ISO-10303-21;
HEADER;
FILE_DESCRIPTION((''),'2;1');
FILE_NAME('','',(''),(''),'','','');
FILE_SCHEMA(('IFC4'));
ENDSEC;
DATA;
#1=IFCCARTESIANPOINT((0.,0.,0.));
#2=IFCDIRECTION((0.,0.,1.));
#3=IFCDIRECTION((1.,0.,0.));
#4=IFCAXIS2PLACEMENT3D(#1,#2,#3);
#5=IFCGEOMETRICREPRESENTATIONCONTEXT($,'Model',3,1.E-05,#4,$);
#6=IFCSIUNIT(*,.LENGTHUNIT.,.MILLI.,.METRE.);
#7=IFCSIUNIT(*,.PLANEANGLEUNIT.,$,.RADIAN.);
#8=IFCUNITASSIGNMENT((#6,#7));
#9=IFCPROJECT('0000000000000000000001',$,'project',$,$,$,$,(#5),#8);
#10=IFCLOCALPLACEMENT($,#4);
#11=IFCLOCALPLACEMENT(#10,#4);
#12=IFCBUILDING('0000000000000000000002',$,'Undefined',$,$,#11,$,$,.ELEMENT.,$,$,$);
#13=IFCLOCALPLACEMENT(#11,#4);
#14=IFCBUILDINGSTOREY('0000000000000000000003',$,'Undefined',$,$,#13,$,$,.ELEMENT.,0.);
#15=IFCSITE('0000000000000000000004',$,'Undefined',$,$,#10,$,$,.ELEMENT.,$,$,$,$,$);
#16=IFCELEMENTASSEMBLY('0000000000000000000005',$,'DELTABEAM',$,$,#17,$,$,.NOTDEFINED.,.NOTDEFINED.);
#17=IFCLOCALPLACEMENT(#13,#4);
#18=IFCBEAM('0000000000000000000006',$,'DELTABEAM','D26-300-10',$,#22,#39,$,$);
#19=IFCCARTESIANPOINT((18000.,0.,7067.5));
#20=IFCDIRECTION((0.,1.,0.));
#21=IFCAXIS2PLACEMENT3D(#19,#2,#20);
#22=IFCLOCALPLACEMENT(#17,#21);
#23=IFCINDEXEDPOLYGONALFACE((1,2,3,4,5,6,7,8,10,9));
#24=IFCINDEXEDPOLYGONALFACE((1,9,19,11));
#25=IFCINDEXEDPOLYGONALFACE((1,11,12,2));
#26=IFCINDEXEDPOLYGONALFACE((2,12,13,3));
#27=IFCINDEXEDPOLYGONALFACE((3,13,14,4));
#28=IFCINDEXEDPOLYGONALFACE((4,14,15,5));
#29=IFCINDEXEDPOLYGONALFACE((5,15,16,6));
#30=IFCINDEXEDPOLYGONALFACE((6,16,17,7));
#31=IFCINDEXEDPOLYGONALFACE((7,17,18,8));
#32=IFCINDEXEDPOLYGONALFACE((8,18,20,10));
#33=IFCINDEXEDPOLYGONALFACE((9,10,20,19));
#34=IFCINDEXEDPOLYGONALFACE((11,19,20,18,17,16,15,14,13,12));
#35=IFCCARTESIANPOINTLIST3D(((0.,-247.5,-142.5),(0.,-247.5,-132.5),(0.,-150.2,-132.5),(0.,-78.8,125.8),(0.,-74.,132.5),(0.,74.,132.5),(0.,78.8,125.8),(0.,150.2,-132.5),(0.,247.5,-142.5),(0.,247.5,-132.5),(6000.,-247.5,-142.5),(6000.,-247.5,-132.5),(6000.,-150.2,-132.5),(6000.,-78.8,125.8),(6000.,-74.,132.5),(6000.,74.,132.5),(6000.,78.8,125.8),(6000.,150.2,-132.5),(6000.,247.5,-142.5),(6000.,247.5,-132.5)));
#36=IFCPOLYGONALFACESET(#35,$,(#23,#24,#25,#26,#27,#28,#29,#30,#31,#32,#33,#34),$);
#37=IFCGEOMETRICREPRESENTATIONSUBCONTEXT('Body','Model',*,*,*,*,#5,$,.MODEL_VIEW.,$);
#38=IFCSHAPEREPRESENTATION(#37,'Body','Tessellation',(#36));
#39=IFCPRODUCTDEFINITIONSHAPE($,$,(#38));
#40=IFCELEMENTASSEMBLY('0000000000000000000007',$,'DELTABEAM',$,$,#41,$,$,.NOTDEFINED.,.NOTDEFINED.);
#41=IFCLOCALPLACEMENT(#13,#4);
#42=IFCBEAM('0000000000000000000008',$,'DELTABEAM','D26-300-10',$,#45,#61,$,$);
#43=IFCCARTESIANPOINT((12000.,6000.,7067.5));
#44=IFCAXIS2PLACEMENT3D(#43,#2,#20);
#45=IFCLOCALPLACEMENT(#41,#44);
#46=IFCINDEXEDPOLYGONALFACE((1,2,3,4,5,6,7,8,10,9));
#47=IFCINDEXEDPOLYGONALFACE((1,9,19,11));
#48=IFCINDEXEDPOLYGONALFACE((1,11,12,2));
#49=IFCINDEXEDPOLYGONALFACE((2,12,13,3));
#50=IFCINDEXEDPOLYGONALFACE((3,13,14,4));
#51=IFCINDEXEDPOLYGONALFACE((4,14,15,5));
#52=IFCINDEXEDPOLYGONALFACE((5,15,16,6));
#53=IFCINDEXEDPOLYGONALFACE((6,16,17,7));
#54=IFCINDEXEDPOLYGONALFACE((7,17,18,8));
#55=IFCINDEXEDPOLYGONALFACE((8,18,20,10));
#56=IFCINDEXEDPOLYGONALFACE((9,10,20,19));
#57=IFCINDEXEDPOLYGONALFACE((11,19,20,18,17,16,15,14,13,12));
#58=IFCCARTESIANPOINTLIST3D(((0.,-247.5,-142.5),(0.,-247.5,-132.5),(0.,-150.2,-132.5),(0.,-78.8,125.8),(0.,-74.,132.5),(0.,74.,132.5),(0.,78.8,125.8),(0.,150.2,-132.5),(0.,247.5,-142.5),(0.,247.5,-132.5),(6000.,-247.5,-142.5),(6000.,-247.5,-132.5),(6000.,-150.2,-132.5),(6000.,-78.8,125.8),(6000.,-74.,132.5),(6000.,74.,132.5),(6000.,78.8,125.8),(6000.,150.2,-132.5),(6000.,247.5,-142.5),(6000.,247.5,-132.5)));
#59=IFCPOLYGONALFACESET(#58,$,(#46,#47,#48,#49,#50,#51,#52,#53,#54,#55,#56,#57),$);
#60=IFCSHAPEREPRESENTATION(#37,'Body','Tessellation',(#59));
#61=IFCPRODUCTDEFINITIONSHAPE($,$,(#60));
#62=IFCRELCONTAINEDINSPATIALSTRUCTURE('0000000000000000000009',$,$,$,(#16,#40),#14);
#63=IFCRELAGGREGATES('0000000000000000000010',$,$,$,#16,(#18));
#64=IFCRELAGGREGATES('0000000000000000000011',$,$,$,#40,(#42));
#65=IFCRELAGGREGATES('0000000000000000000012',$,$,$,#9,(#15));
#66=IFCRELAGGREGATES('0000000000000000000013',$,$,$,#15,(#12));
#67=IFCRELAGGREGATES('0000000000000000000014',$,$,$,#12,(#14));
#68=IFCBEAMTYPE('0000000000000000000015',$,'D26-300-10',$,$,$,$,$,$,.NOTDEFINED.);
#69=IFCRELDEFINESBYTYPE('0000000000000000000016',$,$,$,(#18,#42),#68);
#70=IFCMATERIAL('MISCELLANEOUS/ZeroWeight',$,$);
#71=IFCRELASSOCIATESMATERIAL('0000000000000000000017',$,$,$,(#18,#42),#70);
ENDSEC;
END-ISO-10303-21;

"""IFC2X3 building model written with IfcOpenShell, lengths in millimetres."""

from ifc_helpers import new_model, si_unit, frame, origin_with_axes, place, context, subcontext, project, spatial, polyline, outline, extrude, material, type_object, element, aggregate, save


model = new_model("IFC2X3")

# Units and contexts
model_context = context("Model", 3, precision=1e-05, world=origin_with_axes())
body_context = subcontext(model_context, "Body", "Model", "MODEL_VIEW")
ifc_project = project(units=[si_unit("LENGTHUNIT", "METRE", prefix="MILLI"), si_unit("PLANEANGLEUNIT", "RADIAN")], contexts=[model_context])

# Site, building, storey
site_placement = place(None, origin_with_axes())
site = spatial("IfcSite", under=ifc_project, at=site_placement, Name="Undefined", CompositionType="ELEMENT")
building_placement = place(site_placement, origin_with_axes())
building = spatial("IfcBuilding", under=site, at=building_placement, Name="Undefined", CompositionType="ELEMENT")
storey_placement = place(building_placement, origin_with_axes())
storey = spatial("IfcBuildingStorey", under=building, at=storey_placement, Name="Undefined", CompositionType="ELEMENT", Elevation=0.0)

# Element assemblies, beams
assembly_1_placement = place(storey_placement, origin_with_axes())
assembly_1 = element("IfcElementAssembly", 1, at=assembly_1_placement, inside=storey, Name="DELTABEAM", AssemblyPlace="NOTDEFINED", PredefinedType="NOTDEFINED")
ifc_material_1 = material(Name="MISCELLANEOUS/ZeroWeight")
beam_type = type_object("IfcBeamType", Name="D26-300-10", PredefinedType="NOTDEFINED")
beam_1_placement = place(assembly_1_placement, frame((18000.0, 0.0, 7067.5), z_axis=(0.0, 0.0, 1.0), x_axis=(0.0, 1.0, 0.0)))
beam_1 = element("IfcBeam", 2, at=beam_1_placement, type_object=beam_type, material=ifc_material_1, Name="DELTABEAM", Description="D26-300-10", context=body_context, shape_type="SweptSolid", body=[
    extrude(outline(polyline([(-75.1, 120.5), (-145.0, -132.5), (247.5, -132.5), (247.5, -142.5), (-247.5, -142.5), (-247.5, -132.5), (-150.2, -132.5), (-78.8, 125.8), (-74.0, 132.5), (74.0, 132.5), (78.8, 125.8), (150.2, -132.5), (145.0, -132.5), (75.1, 120.5), (-75.1, 120.5)])), frame((6000.0, 0.0, 0.0), z_axis=(-1.0, 0.0, 0.0), x_axis=(0.0, -1.0, 0.0)), (0.0, 0.0, 1.0), 6000.0),
])
aggregate(assembly_1, [beam_1])
assembly_2_placement = place(storey_placement, origin_with_axes())
assembly_2 = element("IfcElementAssembly", 3, at=assembly_2_placement, inside=storey, Name="DELTABEAM", AssemblyPlace="NOTDEFINED", PredefinedType="NOTDEFINED")
beam_2_placement = place(assembly_2_placement, frame((12000.0, 6000.0, 7067.5), z_axis=(0.0, 0.0, 1.0), x_axis=(0.0, 1.0, 0.0)))
beam_2 = element("IfcBeam", 4, at=beam_2_placement, type_object=beam_type, material=ifc_material_1, Name="DELTABEAM", Description="D26-300-10", context=body_context, shape_type="SweptSolid", body=[
    extrude(outline(polyline([(-75.1, 120.5), (-145.0, -132.5), (247.5, -132.5), (247.5, -142.5), (-247.5, -142.5), (-247.5, -132.5), (-150.2, -132.5), (-78.8, 125.8), (-74.0, 132.5), (74.0, 132.5), (78.8, 125.8), (150.2, -132.5), (145.0, -132.5), (75.1, 120.5), (-75.1, 120.5)])), frame((6000.0, 0.0, 0.0), z_axis=(-1.0, 0.0, 0.0), x_axis=(0.0, -1.0, 0.0)), (0.0, 0.0, 1.0), 6000.0),
])
aggregate(assembly_2, [beam_2])

save(model, "model.ifc")
